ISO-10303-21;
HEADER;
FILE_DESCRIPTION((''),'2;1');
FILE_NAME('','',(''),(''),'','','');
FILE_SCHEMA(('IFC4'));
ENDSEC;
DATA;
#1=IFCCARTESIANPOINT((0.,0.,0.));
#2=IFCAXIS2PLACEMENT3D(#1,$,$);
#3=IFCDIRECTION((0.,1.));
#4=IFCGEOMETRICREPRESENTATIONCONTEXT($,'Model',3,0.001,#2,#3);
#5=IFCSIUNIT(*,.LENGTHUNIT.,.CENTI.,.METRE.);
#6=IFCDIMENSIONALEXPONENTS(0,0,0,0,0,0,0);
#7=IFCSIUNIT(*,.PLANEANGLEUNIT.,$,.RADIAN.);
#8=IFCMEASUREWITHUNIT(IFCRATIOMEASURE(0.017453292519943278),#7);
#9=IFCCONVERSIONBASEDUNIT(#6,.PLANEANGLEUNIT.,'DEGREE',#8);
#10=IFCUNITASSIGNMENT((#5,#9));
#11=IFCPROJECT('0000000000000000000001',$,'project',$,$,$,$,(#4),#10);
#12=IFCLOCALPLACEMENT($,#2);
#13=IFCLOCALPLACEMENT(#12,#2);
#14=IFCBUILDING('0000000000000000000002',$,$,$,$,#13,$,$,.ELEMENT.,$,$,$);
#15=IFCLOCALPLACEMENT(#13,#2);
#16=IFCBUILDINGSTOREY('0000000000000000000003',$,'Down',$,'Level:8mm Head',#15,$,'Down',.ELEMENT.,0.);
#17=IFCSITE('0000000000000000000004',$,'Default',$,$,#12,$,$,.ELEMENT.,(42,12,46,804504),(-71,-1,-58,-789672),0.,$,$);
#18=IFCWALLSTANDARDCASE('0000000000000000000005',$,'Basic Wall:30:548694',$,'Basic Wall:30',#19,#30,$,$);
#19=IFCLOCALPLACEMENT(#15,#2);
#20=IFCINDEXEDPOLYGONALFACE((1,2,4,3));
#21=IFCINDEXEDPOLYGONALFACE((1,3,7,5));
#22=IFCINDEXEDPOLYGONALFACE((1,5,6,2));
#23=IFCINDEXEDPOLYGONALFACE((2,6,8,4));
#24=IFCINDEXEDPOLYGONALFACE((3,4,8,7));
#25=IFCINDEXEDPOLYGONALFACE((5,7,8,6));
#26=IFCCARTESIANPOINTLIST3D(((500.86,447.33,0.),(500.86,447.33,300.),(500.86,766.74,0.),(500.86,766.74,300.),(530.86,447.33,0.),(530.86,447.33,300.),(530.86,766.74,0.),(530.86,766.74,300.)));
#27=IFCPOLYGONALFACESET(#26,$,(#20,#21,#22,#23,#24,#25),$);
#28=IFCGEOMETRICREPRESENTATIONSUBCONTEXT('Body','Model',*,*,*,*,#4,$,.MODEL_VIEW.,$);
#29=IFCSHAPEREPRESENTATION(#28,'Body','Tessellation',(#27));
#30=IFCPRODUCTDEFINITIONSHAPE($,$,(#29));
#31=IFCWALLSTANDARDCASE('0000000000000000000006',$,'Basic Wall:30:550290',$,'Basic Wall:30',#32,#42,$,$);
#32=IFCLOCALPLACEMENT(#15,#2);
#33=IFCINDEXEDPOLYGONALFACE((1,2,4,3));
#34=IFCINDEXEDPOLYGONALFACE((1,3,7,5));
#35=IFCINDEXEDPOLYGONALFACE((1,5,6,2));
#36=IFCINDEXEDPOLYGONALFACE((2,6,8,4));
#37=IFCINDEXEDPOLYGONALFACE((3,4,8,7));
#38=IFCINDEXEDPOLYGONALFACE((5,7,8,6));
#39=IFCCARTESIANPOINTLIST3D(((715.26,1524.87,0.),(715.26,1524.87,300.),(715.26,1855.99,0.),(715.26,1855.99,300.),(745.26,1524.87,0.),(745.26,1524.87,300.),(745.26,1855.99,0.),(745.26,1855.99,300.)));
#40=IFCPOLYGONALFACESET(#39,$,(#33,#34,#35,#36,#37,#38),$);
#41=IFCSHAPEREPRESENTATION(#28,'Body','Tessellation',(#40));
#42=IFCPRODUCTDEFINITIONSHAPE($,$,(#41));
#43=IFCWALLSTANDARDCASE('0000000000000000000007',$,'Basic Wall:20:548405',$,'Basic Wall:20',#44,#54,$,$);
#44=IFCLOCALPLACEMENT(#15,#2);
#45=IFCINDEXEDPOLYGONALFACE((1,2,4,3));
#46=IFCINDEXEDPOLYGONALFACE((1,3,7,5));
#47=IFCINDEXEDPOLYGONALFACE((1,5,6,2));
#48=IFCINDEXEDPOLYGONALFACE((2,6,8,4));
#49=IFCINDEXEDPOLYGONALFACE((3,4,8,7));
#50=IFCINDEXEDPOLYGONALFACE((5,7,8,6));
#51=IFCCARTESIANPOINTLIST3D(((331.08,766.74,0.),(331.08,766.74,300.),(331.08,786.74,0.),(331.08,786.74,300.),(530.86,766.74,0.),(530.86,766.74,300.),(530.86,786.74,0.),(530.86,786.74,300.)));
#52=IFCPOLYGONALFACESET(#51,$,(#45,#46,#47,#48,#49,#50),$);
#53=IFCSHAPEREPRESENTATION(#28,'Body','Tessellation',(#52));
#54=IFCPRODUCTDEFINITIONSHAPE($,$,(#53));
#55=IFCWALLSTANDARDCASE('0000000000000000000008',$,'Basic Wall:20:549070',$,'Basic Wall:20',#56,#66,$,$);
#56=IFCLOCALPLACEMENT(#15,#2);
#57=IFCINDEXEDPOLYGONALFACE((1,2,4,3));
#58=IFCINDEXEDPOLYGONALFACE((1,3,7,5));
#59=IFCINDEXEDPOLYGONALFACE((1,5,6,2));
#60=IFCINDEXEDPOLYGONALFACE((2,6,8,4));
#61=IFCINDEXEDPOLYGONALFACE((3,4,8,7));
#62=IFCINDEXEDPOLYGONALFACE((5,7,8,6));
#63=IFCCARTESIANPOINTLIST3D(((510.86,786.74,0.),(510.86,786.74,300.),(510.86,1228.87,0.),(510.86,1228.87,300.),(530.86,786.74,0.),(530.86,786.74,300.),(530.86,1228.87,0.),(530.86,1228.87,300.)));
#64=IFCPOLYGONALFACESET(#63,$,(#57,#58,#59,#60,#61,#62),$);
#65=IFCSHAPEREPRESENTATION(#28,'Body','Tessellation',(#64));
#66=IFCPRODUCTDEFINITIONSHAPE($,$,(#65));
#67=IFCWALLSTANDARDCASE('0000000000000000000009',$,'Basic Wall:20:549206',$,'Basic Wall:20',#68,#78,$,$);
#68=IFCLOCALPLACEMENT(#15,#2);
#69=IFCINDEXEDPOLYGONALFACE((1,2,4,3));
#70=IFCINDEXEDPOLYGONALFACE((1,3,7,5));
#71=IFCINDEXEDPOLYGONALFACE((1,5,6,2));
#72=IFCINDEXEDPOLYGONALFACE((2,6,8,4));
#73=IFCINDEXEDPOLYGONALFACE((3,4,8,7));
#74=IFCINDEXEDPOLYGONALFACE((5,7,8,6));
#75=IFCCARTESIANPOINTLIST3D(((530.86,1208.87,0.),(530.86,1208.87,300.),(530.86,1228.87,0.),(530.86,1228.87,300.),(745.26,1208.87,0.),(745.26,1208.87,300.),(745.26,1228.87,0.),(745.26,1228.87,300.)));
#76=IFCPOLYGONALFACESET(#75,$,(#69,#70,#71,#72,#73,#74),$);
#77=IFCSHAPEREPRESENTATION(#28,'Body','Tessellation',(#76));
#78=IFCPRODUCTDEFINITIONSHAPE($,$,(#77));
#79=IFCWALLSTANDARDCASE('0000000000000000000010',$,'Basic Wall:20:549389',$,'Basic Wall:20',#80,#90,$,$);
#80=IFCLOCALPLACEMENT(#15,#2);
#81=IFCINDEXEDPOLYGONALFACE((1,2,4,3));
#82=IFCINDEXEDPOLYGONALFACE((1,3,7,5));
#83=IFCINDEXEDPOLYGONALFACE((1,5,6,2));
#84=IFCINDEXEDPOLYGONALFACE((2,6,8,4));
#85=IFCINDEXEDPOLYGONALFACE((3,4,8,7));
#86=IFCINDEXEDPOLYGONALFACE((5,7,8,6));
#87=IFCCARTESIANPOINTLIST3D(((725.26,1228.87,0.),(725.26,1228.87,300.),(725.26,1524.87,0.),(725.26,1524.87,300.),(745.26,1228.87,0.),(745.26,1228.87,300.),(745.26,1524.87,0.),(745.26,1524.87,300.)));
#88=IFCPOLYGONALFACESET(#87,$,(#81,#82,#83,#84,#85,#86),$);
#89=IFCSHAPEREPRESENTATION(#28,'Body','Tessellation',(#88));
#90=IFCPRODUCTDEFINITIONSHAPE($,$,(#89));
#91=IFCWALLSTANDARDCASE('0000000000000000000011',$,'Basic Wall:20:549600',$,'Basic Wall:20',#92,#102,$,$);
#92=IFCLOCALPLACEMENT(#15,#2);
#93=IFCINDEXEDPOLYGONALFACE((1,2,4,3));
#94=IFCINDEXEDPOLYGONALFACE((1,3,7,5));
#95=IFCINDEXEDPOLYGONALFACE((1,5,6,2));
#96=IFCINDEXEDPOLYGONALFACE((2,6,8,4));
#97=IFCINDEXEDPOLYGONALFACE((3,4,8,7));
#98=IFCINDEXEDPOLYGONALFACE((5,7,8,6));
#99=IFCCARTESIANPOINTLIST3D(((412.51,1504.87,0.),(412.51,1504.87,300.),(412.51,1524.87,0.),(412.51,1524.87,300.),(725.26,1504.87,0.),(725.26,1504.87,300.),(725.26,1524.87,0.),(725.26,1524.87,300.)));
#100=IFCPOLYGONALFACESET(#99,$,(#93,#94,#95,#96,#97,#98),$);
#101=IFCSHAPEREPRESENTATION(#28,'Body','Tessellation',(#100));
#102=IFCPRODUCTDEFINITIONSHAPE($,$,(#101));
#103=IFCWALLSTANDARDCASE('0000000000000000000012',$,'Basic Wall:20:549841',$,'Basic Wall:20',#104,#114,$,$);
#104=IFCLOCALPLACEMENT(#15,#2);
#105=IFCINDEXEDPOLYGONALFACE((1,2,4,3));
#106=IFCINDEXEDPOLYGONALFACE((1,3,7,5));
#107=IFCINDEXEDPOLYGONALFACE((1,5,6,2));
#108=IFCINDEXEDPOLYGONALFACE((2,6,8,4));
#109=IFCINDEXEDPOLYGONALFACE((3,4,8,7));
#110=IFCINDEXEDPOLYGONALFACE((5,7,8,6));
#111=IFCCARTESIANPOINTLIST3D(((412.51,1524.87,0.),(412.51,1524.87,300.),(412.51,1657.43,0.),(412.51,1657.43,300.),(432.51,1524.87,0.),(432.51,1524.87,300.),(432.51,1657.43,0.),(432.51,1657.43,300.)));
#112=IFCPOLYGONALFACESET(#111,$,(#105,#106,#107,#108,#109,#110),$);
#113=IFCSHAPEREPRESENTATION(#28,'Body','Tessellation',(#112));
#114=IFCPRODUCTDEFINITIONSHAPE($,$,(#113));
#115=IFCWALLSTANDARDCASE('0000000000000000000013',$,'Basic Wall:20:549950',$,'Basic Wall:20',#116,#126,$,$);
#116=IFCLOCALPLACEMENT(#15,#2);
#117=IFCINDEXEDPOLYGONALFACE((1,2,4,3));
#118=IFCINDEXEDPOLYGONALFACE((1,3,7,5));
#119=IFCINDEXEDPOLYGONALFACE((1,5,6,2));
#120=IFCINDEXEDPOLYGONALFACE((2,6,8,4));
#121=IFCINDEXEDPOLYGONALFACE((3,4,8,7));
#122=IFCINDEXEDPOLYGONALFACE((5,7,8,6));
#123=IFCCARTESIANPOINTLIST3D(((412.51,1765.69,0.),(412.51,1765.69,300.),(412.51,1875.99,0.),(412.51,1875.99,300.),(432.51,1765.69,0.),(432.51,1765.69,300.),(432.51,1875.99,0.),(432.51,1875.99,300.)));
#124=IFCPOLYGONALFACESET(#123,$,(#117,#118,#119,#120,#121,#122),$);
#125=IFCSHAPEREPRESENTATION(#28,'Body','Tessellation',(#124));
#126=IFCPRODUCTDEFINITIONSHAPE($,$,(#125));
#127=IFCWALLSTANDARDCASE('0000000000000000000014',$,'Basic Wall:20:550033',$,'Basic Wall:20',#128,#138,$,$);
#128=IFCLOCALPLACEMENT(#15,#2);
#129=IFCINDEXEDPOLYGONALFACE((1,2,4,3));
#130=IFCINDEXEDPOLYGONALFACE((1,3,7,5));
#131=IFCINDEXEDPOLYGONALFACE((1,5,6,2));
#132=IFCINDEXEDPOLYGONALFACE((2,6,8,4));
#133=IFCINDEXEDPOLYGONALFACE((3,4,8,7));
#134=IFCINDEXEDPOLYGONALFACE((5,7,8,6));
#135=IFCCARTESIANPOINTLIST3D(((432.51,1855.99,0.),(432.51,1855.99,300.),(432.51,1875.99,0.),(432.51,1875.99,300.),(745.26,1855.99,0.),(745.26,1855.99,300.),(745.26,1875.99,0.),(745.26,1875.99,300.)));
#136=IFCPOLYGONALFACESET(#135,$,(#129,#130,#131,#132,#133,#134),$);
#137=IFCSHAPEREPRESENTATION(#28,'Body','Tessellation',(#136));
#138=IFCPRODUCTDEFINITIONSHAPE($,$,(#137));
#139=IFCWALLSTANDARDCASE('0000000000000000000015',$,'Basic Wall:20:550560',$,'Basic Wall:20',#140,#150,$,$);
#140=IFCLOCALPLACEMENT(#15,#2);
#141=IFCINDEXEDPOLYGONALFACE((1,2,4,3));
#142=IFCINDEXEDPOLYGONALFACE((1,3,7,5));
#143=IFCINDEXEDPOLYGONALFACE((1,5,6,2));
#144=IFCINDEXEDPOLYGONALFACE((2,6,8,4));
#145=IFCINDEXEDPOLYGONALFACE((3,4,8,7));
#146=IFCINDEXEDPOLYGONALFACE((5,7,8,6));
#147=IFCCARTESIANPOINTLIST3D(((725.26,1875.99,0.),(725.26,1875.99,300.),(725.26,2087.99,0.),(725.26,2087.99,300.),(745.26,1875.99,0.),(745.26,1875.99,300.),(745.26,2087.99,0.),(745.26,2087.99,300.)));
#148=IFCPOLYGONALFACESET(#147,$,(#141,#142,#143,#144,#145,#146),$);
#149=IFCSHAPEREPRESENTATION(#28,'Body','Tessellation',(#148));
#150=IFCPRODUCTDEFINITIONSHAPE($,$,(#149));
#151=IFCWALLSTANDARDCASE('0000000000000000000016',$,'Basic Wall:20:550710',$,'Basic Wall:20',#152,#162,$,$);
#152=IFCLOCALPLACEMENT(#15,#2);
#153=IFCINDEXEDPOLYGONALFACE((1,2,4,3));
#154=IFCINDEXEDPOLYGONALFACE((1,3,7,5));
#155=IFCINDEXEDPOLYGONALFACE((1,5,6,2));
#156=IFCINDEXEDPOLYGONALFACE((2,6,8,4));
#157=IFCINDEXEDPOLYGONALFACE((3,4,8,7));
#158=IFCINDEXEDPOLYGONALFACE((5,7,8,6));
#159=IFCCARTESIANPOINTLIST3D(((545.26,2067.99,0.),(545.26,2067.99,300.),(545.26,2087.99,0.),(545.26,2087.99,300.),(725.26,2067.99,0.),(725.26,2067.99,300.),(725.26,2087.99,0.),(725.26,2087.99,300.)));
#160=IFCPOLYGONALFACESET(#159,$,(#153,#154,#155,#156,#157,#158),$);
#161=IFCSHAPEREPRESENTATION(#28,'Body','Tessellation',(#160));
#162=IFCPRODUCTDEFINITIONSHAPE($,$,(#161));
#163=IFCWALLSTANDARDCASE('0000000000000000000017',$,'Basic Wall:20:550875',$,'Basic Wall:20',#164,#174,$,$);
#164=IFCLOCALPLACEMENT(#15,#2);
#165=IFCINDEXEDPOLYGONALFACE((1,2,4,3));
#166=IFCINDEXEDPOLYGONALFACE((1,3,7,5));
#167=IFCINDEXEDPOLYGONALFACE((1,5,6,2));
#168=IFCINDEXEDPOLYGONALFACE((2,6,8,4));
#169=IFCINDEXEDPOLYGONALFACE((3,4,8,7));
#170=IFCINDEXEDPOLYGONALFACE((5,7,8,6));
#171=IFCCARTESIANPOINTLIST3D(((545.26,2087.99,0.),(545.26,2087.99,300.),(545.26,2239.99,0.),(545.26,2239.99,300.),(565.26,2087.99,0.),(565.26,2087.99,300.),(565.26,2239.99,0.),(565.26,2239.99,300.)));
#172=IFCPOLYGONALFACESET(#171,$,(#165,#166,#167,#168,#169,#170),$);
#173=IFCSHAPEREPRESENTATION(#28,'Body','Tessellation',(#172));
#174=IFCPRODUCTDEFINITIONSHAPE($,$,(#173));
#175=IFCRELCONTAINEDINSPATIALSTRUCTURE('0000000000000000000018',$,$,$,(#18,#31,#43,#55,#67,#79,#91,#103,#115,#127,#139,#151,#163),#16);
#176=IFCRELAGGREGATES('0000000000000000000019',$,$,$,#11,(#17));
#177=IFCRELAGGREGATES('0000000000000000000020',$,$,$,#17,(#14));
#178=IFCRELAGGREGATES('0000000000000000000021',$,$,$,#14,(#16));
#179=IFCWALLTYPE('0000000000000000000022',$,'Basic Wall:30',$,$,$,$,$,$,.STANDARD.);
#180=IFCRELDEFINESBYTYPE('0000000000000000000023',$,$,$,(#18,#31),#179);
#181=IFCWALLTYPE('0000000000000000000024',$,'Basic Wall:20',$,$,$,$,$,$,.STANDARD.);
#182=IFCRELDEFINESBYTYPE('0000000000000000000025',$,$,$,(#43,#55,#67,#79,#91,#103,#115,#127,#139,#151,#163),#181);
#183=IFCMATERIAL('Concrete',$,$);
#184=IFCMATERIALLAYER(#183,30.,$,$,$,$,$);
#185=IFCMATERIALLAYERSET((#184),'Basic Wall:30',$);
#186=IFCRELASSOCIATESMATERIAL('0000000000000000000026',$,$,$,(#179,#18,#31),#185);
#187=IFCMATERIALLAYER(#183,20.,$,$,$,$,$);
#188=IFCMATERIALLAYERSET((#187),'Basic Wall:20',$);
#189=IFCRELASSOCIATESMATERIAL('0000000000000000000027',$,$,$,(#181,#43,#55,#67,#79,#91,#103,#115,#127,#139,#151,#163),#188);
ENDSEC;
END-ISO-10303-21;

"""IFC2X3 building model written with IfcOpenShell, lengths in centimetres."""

from ifc_helpers import new_model, entity, si_unit, converted_unit, direction, frame, frame_2d, origin, place, context, subcontext, project, spatial, rectangle, extrude, material, layer, layer_set, layer_usage, type_object, element, save


model = new_model("IFC2X3")

# Units and contexts
model_context = context("Model", 3, precision=0.001, world=origin(), true_north=direction((0.0, 1.0)))
body_context = subcontext(model_context, "Body", "Model", "MODEL_VIEW")
ifc_project = project(units=[si_unit("LENGTHUNIT", "METRE", prefix="CENTI"), converted_unit("PLANEANGLEUNIT", "DEGREE", entity("IfcRatioMeasure", 0.017453292519943278), si_unit("PLANEANGLEUNIT", "RADIAN"), dimensions=[0, 0, 0, 0, 0, 0, 0])], contexts=[model_context])

# Site, building, storey
site_placement = place(None, origin())
site = spatial("IfcSite", under=ifc_project, at=site_placement, Name="Default", CompositionType="ELEMENT", RefLatitude=(42, 12, 46, 804504), RefLongitude=(-71, -1, -58, -789672), RefElevation=0.0)
building_placement = place(site_placement, origin())
building = spatial("IfcBuilding", under=site, at=building_placement, CompositionType="ELEMENT")
storey_placement = place(building_placement, origin())
storey = spatial("IfcBuildingStorey", under=building, at=storey_placement, Name="Down", ObjectType="Level:8mm Head", LongName="Down", CompositionType="ELEMENT", Elevation=0.0)

# Walls
ifc_material = material(Name="Concrete")
ifc_layer_1 = layer(ifc_material, 30.0)
ifc_layer_set_1 = layer_set([ifc_layer_1], Name="Basic Wall:30")
ifc_layer_usage_1 = layer_usage(ifc_layer_set_1, "AXIS2", "NEGATIVE", 15.0)
wall_type_1 = type_object("IfcWallType", Name="Basic Wall:30", PredefinedType="STANDARD", material=ifc_layer_set_1)
wall_1_placement = place(storey_placement, frame((515.86, 766.74, 0.0), z_axis=(0.0, 0.0, 1.0), x_axis=(0.0, -1.0, 0.0)))
element("IfcWallStandardCase", 1, at=wall_1_placement, inside=storey, type_object=wall_type_1, material=ifc_layer_usage_1, Name="Basic Wall:30:548694", ObjectType="Basic Wall:30", context=body_context, shape_type="SweptSolid", body=[
    extrude(rectangle(XDim=319.41, YDim=30.0, at=frame_2d((159.7, 0.0), x_axis=(-1.0, 0.0))), origin(), (0.0, 0.0, 1.0), 300.0),
])
ifc_layer_usage_2 = layer_usage(ifc_layer_set_1, "AXIS2", "NEGATIVE", 15.0)
wall_2_placement = place(storey_placement, frame((730.26, 1855.99, 0.0), z_axis=(0.0, 0.0, 1.0), x_axis=(0.0, -1.0, 0.0)))
element("IfcWallStandardCase", 2, at=wall_2_placement, inside=storey, type_object=wall_type_1, material=ifc_layer_usage_2, Name="Basic Wall:30:550290", ObjectType="Basic Wall:30", context=body_context, shape_type="SweptSolid", body=[
    extrude(rectangle(XDim=331.12, YDim=30.0, at=frame_2d((165.56, 0.0), x_axis=(-1.0, 0.0))), origin(), (0.0, 0.0, 1.0), 300.0),
])
ifc_layer_2 = layer(ifc_material, 20.0)
ifc_layer_set_2 = layer_set([ifc_layer_2], Name="Basic Wall:20")
ifc_layer_usage_3 = layer_usage(ifc_layer_set_2, "AXIS2", "NEGATIVE", 10.0)
wall_type_2 = type_object("IfcWallType", Name="Basic Wall:20", PredefinedType="STANDARD", material=ifc_layer_set_2)
wall_3_placement = place(storey_placement, frame((331.08, 776.74, 0.0)))
element("IfcWallStandardCase", 3, at=wall_3_placement, inside=storey, type_object=wall_type_2, material=ifc_layer_usage_3, Name="Basic Wall:20:548405", ObjectType="Basic Wall:20", context=body_context, shape_type="SweptSolid", body=[
    extrude(rectangle(XDim=199.78, YDim=20.0, at=frame_2d((99.89, 0.0), x_axis=(-1.0, 0.0))), origin(), (0.0, 0.0, 1.0), 300.0),
])
ifc_layer_usage_4 = layer_usage(ifc_layer_set_2, "AXIS2", "POSITIVE", -10.0)
wall_4_placement = place(storey_placement, frame((520.86, 786.74, 0.0), z_axis=(0.0, 0.0, 1.0), x_axis=(0.0, 1.0, 0.0)))
element("IfcWallStandardCase", 4, at=wall_4_placement, inside=storey, type_object=wall_type_2, material=ifc_layer_usage_4, Name="Basic Wall:20:549070", ObjectType="Basic Wall:20", context=body_context, shape_type="SweptSolid", body=[
    extrude(rectangle(XDim=442.14, YDim=20.0, at=frame_2d((221.07, 0.0), x_axis=(-1.0, 0.0))), origin(), (0.0, 0.0, 1.0), 300.0),
])
ifc_layer_usage_5 = layer_usage(ifc_layer_set_2, "AXIS2", "NEGATIVE", 10.0)
wall_5_placement = place(storey_placement, frame((530.86, 1218.87, 0.0)))
element("IfcWallStandardCase", 5, at=wall_5_placement, inside=storey, type_object=wall_type_2, material=ifc_layer_usage_5, Name="Basic Wall:20:549206", ObjectType="Basic Wall:20", context=body_context, shape_type="SweptSolid", body=[
    extrude(rectangle(XDim=214.4, YDim=20.0, at=frame_2d((107.2, 0.0), x_axis=(-1.0, 0.0))), origin(), (0.0, 0.0, 1.0), 300.0),
])
ifc_layer_usage_6 = layer_usage(ifc_layer_set_2, "AXIS2", "POSITIVE", -10.0)
wall_6_placement = place(storey_placement, frame((735.26, 1228.87, 0.0), z_axis=(0.0, 0.0, 1.0), x_axis=(0.0, 1.0, 0.0)))
element("IfcWallStandardCase", 6, at=wall_6_placement, inside=storey, type_object=wall_type_2, material=ifc_layer_usage_6, Name="Basic Wall:20:549389", ObjectType="Basic Wall:20", context=body_context, shape_type="SweptSolid", body=[
    extrude(rectangle(XDim=296.0, YDim=20.0, at=frame_2d((148.0, 0.0), x_axis=(-1.0, 0.0))), origin(), (0.0, 0.0, 1.0), 300.0),
])
ifc_layer_usage_7 = layer_usage(ifc_layer_set_2, "AXIS2", "NEGATIVE", 10.0)
wall_7_placement = place(storey_placement, frame((725.26, 1514.87, 0.0), z_axis=(0.0, 0.0, 1.0), x_axis=(-1.0, 0.0, 0.0)))
element("IfcWallStandardCase", 7, at=wall_7_placement, inside=storey, type_object=wall_type_2, material=ifc_layer_usage_7, Name="Basic Wall:20:549600", ObjectType="Basic Wall:20", context=body_context, shape_type="SweptSolid", body=[
    extrude(rectangle(XDim=312.75, YDim=20.0, at=frame_2d((156.38, 0.0), x_axis=(-1.0, 0.0))), origin(), (0.0, 0.0, 1.0), 300.0),
])
ifc_layer_usage_8 = layer_usage(ifc_layer_set_2, "AXIS2", "NEGATIVE", 10.0)
wall_8_placement = place(storey_placement, frame((422.51, 1524.87, 0.0), z_axis=(0.0, 0.0, 1.0), x_axis=(0.0, 1.0, 0.0)))
element("IfcWallStandardCase", 8, at=wall_8_placement, inside=storey, type_object=wall_type_2, material=ifc_layer_usage_8, Name="Basic Wall:20:549841", ObjectType="Basic Wall:20", context=body_context, shape_type="SweptSolid", body=[
    extrude(rectangle(XDim=132.56, YDim=20.0, at=frame_2d((66.28, 0.0), x_axis=(-1.0, 0.0))), origin(), (0.0, 0.0, 1.0), 300.0),
])
ifc_layer_usage_9 = layer_usage(ifc_layer_set_2, "AXIS2", "NEGATIVE", 10.0)
wall_9_placement = place(storey_placement, frame((422.51, 1765.69, 0.0), z_axis=(0.0, 0.0, 1.0), x_axis=(0.0, 1.0, 0.0)))
element("IfcWallStandardCase", 9, at=wall_9_placement, inside=storey, type_object=wall_type_2, material=ifc_layer_usage_9, Name="Basic Wall:20:549950", ObjectType="Basic Wall:20", context=body_context, shape_type="SweptSolid", body=[
    extrude(rectangle(XDim=110.3, YDim=20.0, at=frame_2d((55.15, 0.0), x_axis=(-1.0, 0.0))), origin(), (0.0, 0.0, 1.0), 300.0),
])
ifc_layer_usage_10 = layer_usage(ifc_layer_set_2, "AXIS2", "NEGATIVE", 10.0)
wall_10_placement = place(storey_placement, frame((432.51, 1865.99, 0.0)))
element("IfcWallStandardCase", 10, at=wall_10_placement, inside=storey, type_object=wall_type_2, material=ifc_layer_usage_10, Name="Basic Wall:20:550033", ObjectType="Basic Wall:20", context=body_context, shape_type="SweptSolid", body=[
    extrude(rectangle(XDim=312.75, YDim=20.0, at=frame_2d((156.38, 0.0), x_axis=(-1.0, 0.0))), origin(), (0.0, 0.0, 1.0), 300.0),
])
ifc_layer_usage_11 = layer_usage(ifc_layer_set_2, "AXIS2", "POSITIVE", -10.0)
wall_11_placement = place(storey_placement, frame((735.26, 1875.99, 0.0), z_axis=(0.0, 0.0, 1.0), x_axis=(0.0, 1.0, 0.0)))
element("IfcWallStandardCase", 11, at=wall_11_placement, inside=storey, type_object=wall_type_2, material=ifc_layer_usage_11, Name="Basic Wall:20:550560", ObjectType="Basic Wall:20", context=body_context, shape_type="SweptSolid", body=[
    extrude(rectangle(XDim=212.0, YDim=20.0, at=frame_2d((106.0, 0.0), x_axis=(-1.0, 0.0))), origin(), (0.0, 0.0, 1.0), 300.0),
])
ifc_layer_usage_12 = layer_usage(ifc_layer_set_2, "AXIS2", "POSITIVE", -10.0)
wall_12_placement = place(storey_placement, frame((725.26, 2077.99, 0.0), z_axis=(0.0, 0.0, 1.0), x_axis=(-1.0, 0.0, 0.0)))
element("IfcWallStandardCase", 12, at=wall_12_placement, inside=storey, type_object=wall_type_2, material=ifc_layer_usage_12, Name="Basic Wall:20:550710", ObjectType="Basic Wall:20", context=body_context, shape_type="SweptSolid", body=[
    extrude(rectangle(XDim=180.0, YDim=20.0, at=frame_2d((90.0, 0.0), x_axis=(-1.0, 0.0))), origin(), (0.0, 0.0, 1.0), 300.0),
])
ifc_layer_usage_13 = layer_usage(ifc_layer_set_2, "AXIS2", "NEGATIVE", 10.0)
wall_13_placement = place(storey_placement, frame((555.26, 2087.99, 0.0), z_axis=(0.0, 0.0, 1.0), x_axis=(0.0, 1.0, 0.0)))
element("IfcWallStandardCase", 13, at=wall_13_placement, inside=storey, type_object=wall_type_2, material=ifc_layer_usage_13, Name="Basic Wall:20:550875", ObjectType="Basic Wall:20", context=body_context, shape_type="SweptSolid", body=[
    extrude(rectangle(XDim=152.0, YDim=20.0, at=frame_2d((76.0, 0.0), x_axis=(-1.0, 0.0))), origin(), (0.0, 0.0, 1.0), 300.0),
])

save(model, "model.ifc")
